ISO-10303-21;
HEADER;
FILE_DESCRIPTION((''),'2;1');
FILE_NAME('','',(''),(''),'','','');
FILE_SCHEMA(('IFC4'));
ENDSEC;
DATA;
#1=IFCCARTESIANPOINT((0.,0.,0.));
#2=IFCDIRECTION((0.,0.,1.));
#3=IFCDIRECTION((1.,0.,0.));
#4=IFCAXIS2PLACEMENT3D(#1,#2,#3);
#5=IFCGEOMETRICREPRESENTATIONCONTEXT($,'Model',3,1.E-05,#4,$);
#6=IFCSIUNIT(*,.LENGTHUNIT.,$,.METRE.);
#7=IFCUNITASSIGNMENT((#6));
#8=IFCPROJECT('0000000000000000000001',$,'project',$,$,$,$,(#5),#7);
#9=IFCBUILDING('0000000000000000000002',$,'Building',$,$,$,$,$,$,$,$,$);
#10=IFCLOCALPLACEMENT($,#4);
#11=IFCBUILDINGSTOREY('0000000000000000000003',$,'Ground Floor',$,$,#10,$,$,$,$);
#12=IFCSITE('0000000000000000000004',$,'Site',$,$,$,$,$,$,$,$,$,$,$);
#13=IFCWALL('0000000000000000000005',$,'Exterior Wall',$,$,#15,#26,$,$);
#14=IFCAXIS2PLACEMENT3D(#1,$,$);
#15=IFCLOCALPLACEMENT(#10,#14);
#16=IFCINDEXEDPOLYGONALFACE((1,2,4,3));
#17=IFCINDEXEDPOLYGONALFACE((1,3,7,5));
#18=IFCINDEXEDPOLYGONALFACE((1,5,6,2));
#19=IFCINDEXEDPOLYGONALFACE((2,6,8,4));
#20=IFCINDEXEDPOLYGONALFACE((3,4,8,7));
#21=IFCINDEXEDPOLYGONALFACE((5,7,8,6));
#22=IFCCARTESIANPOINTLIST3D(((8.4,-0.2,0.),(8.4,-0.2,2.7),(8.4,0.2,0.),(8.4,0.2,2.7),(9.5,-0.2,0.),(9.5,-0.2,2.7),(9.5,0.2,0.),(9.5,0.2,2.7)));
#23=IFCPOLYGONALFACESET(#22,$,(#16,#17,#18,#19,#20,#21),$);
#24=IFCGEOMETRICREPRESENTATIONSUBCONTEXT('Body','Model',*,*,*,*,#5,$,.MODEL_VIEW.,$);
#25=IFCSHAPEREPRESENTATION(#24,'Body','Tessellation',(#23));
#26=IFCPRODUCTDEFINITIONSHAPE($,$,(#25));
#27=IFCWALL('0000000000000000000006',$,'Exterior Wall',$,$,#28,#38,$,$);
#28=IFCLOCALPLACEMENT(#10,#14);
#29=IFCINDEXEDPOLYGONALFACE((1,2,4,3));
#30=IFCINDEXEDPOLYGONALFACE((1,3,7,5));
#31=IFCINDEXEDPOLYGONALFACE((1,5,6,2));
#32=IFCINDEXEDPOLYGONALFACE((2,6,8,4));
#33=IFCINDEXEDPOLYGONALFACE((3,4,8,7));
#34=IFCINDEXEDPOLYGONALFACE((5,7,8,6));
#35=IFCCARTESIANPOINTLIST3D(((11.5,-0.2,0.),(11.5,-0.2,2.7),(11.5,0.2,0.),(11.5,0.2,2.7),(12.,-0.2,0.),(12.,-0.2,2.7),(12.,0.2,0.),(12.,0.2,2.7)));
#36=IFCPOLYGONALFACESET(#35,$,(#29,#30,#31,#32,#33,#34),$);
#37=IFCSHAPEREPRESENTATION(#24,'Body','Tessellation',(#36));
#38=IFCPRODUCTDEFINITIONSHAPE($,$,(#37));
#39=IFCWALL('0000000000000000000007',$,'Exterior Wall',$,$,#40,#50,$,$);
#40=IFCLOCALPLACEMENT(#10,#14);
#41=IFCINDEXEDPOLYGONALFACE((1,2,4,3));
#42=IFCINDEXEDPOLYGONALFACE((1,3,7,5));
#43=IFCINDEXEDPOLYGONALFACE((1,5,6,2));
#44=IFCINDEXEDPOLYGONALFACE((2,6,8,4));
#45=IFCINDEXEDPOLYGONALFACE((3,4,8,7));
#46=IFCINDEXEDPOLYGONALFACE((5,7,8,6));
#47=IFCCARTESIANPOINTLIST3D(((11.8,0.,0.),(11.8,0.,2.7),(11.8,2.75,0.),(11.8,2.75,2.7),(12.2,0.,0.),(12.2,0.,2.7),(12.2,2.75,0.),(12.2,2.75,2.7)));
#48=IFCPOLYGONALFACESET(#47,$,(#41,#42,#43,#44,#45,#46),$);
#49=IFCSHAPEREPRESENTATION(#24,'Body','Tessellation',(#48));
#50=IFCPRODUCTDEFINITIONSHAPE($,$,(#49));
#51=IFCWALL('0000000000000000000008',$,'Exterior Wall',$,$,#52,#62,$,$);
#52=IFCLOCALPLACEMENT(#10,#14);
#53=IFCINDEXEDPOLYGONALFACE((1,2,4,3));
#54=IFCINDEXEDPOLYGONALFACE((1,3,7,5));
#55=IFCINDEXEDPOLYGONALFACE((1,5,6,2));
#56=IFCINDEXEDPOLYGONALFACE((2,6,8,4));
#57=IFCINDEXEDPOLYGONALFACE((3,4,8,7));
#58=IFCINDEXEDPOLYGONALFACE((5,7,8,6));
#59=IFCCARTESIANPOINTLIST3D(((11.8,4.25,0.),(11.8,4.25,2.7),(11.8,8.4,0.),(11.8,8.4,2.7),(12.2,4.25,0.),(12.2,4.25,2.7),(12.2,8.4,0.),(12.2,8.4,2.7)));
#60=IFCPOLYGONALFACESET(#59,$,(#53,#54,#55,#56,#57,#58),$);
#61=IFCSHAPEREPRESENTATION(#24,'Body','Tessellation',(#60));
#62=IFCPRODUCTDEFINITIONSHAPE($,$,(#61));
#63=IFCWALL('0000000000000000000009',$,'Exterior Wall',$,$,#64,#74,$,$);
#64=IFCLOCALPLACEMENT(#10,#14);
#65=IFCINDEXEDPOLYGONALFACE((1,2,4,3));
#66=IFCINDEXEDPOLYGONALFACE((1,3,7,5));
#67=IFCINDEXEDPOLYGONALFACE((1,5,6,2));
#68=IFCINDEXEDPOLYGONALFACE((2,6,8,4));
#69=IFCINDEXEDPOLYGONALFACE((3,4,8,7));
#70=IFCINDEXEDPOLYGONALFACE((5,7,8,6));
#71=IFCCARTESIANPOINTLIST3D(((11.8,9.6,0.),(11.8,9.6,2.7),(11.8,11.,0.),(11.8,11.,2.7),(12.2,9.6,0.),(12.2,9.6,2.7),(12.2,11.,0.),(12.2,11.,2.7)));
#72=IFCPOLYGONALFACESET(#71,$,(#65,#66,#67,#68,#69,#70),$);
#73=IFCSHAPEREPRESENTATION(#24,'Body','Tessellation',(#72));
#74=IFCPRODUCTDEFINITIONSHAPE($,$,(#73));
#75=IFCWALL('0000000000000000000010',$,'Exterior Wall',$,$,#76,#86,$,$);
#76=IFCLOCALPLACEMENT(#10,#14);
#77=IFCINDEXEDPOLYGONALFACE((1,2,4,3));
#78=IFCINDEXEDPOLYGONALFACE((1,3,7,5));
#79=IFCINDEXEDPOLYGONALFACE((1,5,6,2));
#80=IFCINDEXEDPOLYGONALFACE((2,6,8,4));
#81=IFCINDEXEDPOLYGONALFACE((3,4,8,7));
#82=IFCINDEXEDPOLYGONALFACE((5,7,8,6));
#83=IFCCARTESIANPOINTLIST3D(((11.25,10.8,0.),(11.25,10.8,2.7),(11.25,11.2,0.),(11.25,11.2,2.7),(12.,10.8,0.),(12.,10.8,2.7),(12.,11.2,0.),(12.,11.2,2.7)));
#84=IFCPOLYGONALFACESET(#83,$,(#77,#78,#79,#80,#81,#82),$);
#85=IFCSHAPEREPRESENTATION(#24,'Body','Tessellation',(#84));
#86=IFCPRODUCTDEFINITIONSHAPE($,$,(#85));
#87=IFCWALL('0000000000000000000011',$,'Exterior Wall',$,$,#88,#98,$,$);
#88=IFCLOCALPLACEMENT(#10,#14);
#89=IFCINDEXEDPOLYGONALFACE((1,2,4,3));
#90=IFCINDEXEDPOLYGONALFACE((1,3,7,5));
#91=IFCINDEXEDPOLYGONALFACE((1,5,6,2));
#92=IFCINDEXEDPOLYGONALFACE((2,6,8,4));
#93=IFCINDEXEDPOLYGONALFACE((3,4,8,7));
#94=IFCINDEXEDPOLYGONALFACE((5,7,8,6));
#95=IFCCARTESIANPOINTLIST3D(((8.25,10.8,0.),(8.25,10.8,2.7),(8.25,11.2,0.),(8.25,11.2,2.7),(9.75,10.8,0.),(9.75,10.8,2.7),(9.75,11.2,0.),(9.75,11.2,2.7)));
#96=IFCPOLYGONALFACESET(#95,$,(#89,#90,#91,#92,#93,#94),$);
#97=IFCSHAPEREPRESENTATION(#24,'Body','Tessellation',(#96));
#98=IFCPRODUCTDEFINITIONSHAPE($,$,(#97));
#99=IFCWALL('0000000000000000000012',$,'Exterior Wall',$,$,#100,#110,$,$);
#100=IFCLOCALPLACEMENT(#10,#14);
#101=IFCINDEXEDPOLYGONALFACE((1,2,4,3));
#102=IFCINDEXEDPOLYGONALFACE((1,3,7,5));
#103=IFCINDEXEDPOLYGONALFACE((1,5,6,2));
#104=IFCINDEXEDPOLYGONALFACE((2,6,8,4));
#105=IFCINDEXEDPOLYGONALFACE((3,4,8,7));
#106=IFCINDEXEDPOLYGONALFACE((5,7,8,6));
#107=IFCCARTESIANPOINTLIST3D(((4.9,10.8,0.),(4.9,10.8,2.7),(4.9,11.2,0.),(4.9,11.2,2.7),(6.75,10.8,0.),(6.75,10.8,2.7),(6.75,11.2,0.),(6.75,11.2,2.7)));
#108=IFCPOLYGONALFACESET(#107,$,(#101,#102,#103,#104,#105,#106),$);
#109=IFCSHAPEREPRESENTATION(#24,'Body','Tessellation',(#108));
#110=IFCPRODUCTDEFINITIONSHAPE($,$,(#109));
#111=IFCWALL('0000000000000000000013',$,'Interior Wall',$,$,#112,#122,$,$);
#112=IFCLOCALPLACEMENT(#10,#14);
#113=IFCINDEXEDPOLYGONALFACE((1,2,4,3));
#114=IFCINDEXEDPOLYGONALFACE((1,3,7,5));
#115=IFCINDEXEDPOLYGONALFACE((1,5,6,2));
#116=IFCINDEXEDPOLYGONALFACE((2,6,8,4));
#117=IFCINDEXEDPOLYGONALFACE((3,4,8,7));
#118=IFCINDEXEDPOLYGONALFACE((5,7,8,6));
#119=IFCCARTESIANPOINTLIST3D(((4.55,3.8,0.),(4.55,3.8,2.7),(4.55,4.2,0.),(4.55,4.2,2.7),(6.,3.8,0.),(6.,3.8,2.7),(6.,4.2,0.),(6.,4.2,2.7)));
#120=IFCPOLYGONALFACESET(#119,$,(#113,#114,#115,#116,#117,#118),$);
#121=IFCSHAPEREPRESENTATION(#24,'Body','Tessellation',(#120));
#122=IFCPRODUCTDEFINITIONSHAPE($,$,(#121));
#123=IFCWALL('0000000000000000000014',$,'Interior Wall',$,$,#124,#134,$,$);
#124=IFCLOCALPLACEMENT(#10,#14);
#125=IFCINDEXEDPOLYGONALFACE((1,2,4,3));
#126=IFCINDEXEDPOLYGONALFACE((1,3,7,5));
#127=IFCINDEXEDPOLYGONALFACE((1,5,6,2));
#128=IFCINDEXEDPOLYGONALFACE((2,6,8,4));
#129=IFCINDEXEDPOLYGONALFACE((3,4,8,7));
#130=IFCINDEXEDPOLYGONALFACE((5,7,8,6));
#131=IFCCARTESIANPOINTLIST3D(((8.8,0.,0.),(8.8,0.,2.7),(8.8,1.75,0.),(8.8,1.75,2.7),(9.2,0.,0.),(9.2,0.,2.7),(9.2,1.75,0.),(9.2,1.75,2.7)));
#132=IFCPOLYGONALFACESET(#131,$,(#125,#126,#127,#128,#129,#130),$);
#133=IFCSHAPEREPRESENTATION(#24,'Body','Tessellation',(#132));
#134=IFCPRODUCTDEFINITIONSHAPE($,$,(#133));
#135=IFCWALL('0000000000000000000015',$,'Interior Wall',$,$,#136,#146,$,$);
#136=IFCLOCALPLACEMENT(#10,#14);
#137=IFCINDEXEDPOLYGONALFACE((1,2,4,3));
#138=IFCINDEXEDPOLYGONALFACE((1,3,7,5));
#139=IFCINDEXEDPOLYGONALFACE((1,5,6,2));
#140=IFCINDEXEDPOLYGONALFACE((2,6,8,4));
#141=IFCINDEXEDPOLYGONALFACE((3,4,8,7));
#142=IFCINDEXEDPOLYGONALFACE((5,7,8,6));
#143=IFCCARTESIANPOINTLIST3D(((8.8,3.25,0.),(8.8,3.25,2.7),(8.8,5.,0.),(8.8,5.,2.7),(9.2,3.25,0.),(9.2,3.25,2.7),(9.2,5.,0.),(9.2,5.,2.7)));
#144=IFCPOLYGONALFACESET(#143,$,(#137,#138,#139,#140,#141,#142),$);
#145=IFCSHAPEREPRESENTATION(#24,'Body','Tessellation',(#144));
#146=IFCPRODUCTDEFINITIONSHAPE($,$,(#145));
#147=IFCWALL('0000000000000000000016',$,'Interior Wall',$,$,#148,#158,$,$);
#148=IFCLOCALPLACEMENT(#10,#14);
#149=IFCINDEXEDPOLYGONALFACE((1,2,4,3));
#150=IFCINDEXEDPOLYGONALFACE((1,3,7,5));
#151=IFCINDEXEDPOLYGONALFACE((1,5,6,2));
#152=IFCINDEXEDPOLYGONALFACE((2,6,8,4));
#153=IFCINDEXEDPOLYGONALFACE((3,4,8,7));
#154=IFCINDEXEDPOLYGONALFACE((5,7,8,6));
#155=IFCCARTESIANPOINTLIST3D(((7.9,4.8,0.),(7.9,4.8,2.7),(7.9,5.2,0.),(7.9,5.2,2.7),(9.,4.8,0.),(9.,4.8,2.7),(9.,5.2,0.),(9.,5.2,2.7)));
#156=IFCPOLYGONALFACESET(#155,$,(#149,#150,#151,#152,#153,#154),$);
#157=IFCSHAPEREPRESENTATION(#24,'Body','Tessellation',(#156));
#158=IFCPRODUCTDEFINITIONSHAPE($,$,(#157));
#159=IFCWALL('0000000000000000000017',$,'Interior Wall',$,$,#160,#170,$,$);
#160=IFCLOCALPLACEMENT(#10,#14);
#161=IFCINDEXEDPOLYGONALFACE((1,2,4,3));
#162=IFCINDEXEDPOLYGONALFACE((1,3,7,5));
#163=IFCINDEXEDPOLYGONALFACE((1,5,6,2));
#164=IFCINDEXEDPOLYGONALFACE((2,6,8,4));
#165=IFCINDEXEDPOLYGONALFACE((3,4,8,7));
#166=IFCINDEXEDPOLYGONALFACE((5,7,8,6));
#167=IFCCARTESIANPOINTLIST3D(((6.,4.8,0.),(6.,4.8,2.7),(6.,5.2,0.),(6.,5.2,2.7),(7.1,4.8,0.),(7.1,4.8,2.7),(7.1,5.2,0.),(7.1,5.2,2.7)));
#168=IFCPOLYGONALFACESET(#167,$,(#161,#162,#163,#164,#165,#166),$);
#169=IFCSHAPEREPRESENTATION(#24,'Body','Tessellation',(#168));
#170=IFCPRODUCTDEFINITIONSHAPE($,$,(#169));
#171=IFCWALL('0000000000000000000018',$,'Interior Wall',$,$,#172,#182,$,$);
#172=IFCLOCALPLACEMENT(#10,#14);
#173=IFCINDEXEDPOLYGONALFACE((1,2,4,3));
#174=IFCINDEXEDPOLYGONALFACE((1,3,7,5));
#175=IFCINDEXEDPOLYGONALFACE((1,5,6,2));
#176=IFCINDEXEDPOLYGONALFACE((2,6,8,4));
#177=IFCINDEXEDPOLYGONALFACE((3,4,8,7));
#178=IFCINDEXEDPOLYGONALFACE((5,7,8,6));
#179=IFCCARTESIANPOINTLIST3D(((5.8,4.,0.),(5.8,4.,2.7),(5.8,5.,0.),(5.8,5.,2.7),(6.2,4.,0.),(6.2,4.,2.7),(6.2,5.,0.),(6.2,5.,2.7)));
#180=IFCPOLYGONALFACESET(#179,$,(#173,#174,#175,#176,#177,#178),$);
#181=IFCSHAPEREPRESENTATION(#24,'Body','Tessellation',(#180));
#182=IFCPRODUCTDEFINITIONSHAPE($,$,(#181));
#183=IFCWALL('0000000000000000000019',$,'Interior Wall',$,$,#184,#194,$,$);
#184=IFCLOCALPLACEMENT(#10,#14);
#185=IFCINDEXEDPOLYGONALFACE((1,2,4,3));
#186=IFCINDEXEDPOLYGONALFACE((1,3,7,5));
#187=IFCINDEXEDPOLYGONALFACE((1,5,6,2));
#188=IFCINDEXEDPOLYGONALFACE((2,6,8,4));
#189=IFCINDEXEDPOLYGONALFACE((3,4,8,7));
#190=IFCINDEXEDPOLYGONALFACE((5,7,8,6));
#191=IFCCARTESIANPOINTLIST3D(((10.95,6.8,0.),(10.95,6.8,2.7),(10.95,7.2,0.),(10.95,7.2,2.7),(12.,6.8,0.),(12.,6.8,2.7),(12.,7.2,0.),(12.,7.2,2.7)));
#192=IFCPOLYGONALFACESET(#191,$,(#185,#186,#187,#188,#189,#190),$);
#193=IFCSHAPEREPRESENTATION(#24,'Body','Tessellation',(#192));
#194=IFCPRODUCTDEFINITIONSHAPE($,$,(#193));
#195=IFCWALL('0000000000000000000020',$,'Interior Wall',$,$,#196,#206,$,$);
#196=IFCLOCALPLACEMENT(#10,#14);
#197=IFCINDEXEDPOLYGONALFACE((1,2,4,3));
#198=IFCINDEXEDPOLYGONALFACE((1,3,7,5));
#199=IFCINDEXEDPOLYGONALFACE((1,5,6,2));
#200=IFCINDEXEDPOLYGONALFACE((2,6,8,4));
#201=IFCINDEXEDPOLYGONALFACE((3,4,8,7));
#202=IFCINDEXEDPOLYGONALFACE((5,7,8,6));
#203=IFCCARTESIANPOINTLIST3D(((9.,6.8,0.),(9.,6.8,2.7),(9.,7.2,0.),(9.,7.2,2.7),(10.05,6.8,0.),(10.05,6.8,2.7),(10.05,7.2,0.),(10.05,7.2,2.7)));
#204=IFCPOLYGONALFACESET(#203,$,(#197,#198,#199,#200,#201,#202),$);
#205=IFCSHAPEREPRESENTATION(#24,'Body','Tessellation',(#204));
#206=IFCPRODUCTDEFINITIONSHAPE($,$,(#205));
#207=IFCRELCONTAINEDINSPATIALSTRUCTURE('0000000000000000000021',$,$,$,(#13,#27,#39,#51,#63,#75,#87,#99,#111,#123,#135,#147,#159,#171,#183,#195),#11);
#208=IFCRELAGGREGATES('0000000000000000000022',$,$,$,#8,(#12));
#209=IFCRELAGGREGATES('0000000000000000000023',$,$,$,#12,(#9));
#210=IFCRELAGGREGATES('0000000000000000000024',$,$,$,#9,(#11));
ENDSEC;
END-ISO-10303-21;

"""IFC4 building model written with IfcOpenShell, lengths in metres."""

from ifc_helpers import new_model, si_unit, frame, origin_with_axes, place, context, subcontext, project, spatial, indexed_curve, outline, extrude, element, save


model = new_model("IFC4")

# Units and contexts
model_context = context("Model", 3, precision=1e-05, world=origin_with_axes())
body_context = subcontext(model_context, "Body", "Model", "MODEL_VIEW")
ifc_project = project(units=[si_unit("LENGTHUNIT", "METRE")], contexts=[model_context])

# Site, building, storey
site = spatial("IfcSite", under=ifc_project, Name="Site")
building = spatial("IfcBuilding", under=site, Name="Building")
storey_placement = place(None, origin_with_axes())
storey = spatial("IfcBuildingStorey", under=building, at=storey_placement, Name="Ground Floor")

# Walls
wall_1_placement = place(storey_placement, frame((8.4, 0.0, 0.0), z_axis=(0.0, 0.0, 1.0), x_axis=(1.0, 0.0, 0.0)))
element("IfcWall", 1, at=wall_1_placement, inside=storey, Name="Exterior Wall", context=body_context, shape_type="SweptSolid", body=[
    extrude(outline(indexed_curve([(0.0, 0.0), (0.0, 0.4), (1.1, 0.4), (1.1, 0.0), (0.0, 0.0)], self_intersect=False)), frame((0.0, -0.2, 0.0), z_axis=(0.0, 0.0, 1.0), x_axis=(1.0, 0.0, 0.0)), (0.0, 0.0, 1.0), 2.7),
])
wall_2_placement = place(storey_placement, frame((11.5, 0.0, 0.0), z_axis=(0.0, 0.0, 1.0), x_axis=(1.0, 0.0, 0.0)))
element("IfcWall", 2, at=wall_2_placement, inside=storey, Name="Exterior Wall", context=body_context, shape_type="SweptSolid", body=[
    extrude(outline(indexed_curve([(0.0, 0.0), (0.0, 0.4), (0.5, 0.4), (0.5, 0.0), (0.0, 0.0)], self_intersect=False)), frame((0.0, -0.2, 0.0), z_axis=(0.0, 0.0, 1.0), x_axis=(1.0, 0.0, 0.0)), (0.0, 0.0, 1.0), 2.7),
])
wall_3_placement = place(storey_placement, frame((12.0, 0.0, 0.0), z_axis=(0.0, 0.0, 1.0), x_axis=(0.0, 1.0, 0.0)))
element("IfcWall", 3, at=wall_3_placement, inside=storey, Name="Exterior Wall", context=body_context, shape_type="SweptSolid", body=[
    extrude(outline(indexed_curve([(0.0, 0.0), (0.0, 0.4), (2.75, 0.4), (2.75, 0.0), (0.0, 0.0)], self_intersect=False)), frame((0.0, -0.2, 0.0), z_axis=(0.0, 0.0, 1.0), x_axis=(1.0, 0.0, 0.0)), (0.0, 0.0, 1.0), 2.7),
])
wall_4_placement = place(storey_placement, frame((12.0, 4.25, 0.0), z_axis=(0.0, 0.0, 1.0), x_axis=(0.0, 1.0, 0.0)))
element("IfcWall", 4, at=wall_4_placement, inside=storey, Name="Exterior Wall", context=body_context, shape_type="SweptSolid", body=[
    extrude(outline(indexed_curve([(0.0, 0.0), (0.0, 0.4), (4.15, 0.4), (4.15, 0.0), (0.0, 0.0)], self_intersect=False)), frame((0.0, -0.2, 0.0), z_axis=(0.0, 0.0, 1.0), x_axis=(1.0, 0.0, 0.0)), (0.0, 0.0, 1.0), 2.7),
])
wall_5_placement = place(storey_placement, frame((12.0, 9.6, 0.0), z_axis=(0.0, 0.0, 1.0), x_axis=(0.0, 1.0, 0.0)))
element("IfcWall", 5, at=wall_5_placement, inside=storey, Name="Exterior Wall", context=body_context, shape_type="SweptSolid", body=[
    extrude(outline(indexed_curve([(0.0, 0.0), (0.0, 0.4), (1.4, 0.4), (1.4, 0.0), (0.0, 0.0)], self_intersect=False)), frame((0.0, -0.2, 0.0), z_axis=(0.0, 0.0, 1.0), x_axis=(1.0, 0.0, 0.0)), (0.0, 0.0, 1.0), 2.7),
])
wall_6_placement = place(storey_placement, frame((12.0, 11.0, 0.0), z_axis=(0.0, 0.0, 1.0), x_axis=(-1.0, 0.0, 0.0)))
element("IfcWall", 6, at=wall_6_placement, inside=storey, Name="Exterior Wall", context=body_context, shape_type="SweptSolid", body=[
    extrude(outline(indexed_curve([(0.0, 0.0), (0.0, 0.4), (0.75, 0.4), (0.75, 0.0), (0.0, 0.0)], self_intersect=False)), frame((0.0, -0.2, 0.0), z_axis=(0.0, 0.0, 1.0), x_axis=(1.0, 0.0, 0.0)), (0.0, 0.0, 1.0), 2.7),
])
wall_7_placement = place(storey_placement, frame((9.75, 11.0, 0.0), z_axis=(0.0, 0.0, 1.0), x_axis=(-1.0, 0.0, 0.0)))
element("IfcWall", 7, at=wall_7_placement, inside=storey, Name="Exterior Wall", context=body_context, shape_type="SweptSolid", body=[
    extrude(outline(indexed_curve([(0.0, 0.0), (0.0, 0.4), (1.5, 0.4), (1.5, 0.0), (0.0, 0.0)], self_intersect=False)), frame((0.0, -0.2, 0.0), z_axis=(0.0, 0.0, 1.0), x_axis=(1.0, 0.0, 0.0)), (0.0, 0.0, 1.0), 2.7),
])
wall_8_placement = place(storey_placement, frame((6.75, 11.0, 0.0), z_axis=(0.0, 0.0, 1.0), x_axis=(-1.0, 0.0, 0.0)))
element("IfcWall", 8, at=wall_8_placement, inside=storey, Name="Exterior Wall", context=body_context, shape_type="SweptSolid", body=[
    extrude(outline(indexed_curve([(0.0, 0.0), (0.0, 0.4), (1.85, 0.4), (1.85, 0.0), (0.0, 0.0)], self_intersect=False)), frame((0.0, -0.2, 0.0), z_axis=(0.0, 0.0, 1.0), x_axis=(1.0, 0.0, 0.0)), (0.0, 0.0, 1.0), 2.7),
])
wall_9_placement = place(storey_placement, frame((6.0, 4.0, 0.0), z_axis=(0.0, 0.0, 1.0), x_axis=(-1.0, 0.0, 0.0)))
element("IfcWall", 9, at=wall_9_placement, inside=storey, Name="Interior Wall", context=body_context, shape_type="SweptSolid", body=[
    extrude(outline(indexed_curve([(0.0, 0.0), (0.0, 0.4), (1.45, 0.4), (1.45, 0.0), (0.0, 0.0)], self_intersect=False)), frame((0.0, -0.2, 0.0), z_axis=(0.0, 0.0, 1.0), x_axis=(1.0, 0.0, 0.0)), (0.0, 0.0, 1.0), 2.7),
])
for number, where, z_axis, x_axis, name in (
    (10, (9.0, 0.0, 0.0), (0.0, 0.0, 1.0), (0.0, 1.0, 0.0), "Interior Wall"),
    (11, (9.0, 3.25, 0.0), (0.0, 0.0, 1.0), (0.0, 1.0, 0.0), "Interior Wall"),
):
    element("IfcWall", number, at=place(storey_placement, frame(where, z_axis=z_axis, x_axis=x_axis)), inside=storey, Name=name, context=body_context, shape_type="SweptSolid", body=[
        extrude(outline(indexed_curve([(0.0, 0.0), (0.0, 0.4), (1.75, 0.4), (1.75, 0.0), (0.0, 0.0)], self_intersect=False)), frame((0.0, -0.2, 0.0), z_axis=(0.0, 0.0, 1.0), x_axis=(1.0, 0.0, 0.0)), (0.0, 0.0, 1.0), 2.7),
    ])
for number, where, z_axis, x_axis, name in (
    (12, (9.0, 5.0, 0.0), (0.0, 0.0, 1.0), (-1.0, 0.0, 0.0), "Interior Wall"),
    (13, (7.1, 5.0, 0.0), (0.0, 0.0, 1.0), (-1.0, 0.0, 0.0), "Interior Wall"),
):
    element("IfcWall", number, at=place(storey_placement, frame(where, z_axis=z_axis, x_axis=x_axis)), inside=storey, Name=name, context=body_context, shape_type="SweptSolid", body=[
        extrude(outline(indexed_curve([(0.0, 0.0), (0.0, 0.4), (1.1, 0.4), (1.1, 0.0), (0.0, 0.0)], self_intersect=False)), frame((0.0, -0.2, 0.0), z_axis=(0.0, 0.0, 1.0), x_axis=(1.0, 0.0, 0.0)), (0.0, 0.0, 1.0), 2.7),
    ])
wall_10_placement = place(storey_placement, frame((6.0, 5.0, 0.0), z_axis=(0.0, 0.0, 1.0), x_axis=(0.0, -1.0, 0.0)))
element("IfcWall", 14, at=wall_10_placement, inside=storey, Name="Interior Wall", context=body_context, shape_type="SweptSolid", body=[
    extrude(outline(indexed_curve([(0.0, 0.0), (0.0, 0.4), (1.0, 0.4), (1.0, 0.0), (0.0, 0.0)], self_intersect=False)), frame((0.0, -0.2, 0.0), z_axis=(0.0, 0.0, 1.0), x_axis=(1.0, 0.0, 0.0)), (0.0, 0.0, 1.0), 2.7),
])
for number, where, z_axis, x_axis, name in (
    (15, (12.0, 7.0, 0.0), (0.0, 0.0, 1.0), (-1.0, 0.0, 0.0), "Interior Wall"),
    (16, (10.05, 7.0, 0.0), (0.0, 0.0, 1.0), (-1.0, 0.0, 0.0), "Interior Wall"),
):
    element("IfcWall", number, at=place(storey_placement, frame(where, z_axis=z_axis, x_axis=x_axis)), inside=storey, Name=name, context=body_context, shape_type="SweptSolid", body=[
        extrude(outline(indexed_curve([(0.0, 0.0), (0.0, 0.4), (1.05, 0.4), (1.05, 0.0), (0.0, 0.0)], self_intersect=False)), frame((0.0, -0.2, 0.0), z_axis=(0.0, 0.0, 1.0), x_axis=(1.0, 0.0, 0.0)), (0.0, 0.0, 1.0), 2.7),
    ])

save(model, "model.ifc")
